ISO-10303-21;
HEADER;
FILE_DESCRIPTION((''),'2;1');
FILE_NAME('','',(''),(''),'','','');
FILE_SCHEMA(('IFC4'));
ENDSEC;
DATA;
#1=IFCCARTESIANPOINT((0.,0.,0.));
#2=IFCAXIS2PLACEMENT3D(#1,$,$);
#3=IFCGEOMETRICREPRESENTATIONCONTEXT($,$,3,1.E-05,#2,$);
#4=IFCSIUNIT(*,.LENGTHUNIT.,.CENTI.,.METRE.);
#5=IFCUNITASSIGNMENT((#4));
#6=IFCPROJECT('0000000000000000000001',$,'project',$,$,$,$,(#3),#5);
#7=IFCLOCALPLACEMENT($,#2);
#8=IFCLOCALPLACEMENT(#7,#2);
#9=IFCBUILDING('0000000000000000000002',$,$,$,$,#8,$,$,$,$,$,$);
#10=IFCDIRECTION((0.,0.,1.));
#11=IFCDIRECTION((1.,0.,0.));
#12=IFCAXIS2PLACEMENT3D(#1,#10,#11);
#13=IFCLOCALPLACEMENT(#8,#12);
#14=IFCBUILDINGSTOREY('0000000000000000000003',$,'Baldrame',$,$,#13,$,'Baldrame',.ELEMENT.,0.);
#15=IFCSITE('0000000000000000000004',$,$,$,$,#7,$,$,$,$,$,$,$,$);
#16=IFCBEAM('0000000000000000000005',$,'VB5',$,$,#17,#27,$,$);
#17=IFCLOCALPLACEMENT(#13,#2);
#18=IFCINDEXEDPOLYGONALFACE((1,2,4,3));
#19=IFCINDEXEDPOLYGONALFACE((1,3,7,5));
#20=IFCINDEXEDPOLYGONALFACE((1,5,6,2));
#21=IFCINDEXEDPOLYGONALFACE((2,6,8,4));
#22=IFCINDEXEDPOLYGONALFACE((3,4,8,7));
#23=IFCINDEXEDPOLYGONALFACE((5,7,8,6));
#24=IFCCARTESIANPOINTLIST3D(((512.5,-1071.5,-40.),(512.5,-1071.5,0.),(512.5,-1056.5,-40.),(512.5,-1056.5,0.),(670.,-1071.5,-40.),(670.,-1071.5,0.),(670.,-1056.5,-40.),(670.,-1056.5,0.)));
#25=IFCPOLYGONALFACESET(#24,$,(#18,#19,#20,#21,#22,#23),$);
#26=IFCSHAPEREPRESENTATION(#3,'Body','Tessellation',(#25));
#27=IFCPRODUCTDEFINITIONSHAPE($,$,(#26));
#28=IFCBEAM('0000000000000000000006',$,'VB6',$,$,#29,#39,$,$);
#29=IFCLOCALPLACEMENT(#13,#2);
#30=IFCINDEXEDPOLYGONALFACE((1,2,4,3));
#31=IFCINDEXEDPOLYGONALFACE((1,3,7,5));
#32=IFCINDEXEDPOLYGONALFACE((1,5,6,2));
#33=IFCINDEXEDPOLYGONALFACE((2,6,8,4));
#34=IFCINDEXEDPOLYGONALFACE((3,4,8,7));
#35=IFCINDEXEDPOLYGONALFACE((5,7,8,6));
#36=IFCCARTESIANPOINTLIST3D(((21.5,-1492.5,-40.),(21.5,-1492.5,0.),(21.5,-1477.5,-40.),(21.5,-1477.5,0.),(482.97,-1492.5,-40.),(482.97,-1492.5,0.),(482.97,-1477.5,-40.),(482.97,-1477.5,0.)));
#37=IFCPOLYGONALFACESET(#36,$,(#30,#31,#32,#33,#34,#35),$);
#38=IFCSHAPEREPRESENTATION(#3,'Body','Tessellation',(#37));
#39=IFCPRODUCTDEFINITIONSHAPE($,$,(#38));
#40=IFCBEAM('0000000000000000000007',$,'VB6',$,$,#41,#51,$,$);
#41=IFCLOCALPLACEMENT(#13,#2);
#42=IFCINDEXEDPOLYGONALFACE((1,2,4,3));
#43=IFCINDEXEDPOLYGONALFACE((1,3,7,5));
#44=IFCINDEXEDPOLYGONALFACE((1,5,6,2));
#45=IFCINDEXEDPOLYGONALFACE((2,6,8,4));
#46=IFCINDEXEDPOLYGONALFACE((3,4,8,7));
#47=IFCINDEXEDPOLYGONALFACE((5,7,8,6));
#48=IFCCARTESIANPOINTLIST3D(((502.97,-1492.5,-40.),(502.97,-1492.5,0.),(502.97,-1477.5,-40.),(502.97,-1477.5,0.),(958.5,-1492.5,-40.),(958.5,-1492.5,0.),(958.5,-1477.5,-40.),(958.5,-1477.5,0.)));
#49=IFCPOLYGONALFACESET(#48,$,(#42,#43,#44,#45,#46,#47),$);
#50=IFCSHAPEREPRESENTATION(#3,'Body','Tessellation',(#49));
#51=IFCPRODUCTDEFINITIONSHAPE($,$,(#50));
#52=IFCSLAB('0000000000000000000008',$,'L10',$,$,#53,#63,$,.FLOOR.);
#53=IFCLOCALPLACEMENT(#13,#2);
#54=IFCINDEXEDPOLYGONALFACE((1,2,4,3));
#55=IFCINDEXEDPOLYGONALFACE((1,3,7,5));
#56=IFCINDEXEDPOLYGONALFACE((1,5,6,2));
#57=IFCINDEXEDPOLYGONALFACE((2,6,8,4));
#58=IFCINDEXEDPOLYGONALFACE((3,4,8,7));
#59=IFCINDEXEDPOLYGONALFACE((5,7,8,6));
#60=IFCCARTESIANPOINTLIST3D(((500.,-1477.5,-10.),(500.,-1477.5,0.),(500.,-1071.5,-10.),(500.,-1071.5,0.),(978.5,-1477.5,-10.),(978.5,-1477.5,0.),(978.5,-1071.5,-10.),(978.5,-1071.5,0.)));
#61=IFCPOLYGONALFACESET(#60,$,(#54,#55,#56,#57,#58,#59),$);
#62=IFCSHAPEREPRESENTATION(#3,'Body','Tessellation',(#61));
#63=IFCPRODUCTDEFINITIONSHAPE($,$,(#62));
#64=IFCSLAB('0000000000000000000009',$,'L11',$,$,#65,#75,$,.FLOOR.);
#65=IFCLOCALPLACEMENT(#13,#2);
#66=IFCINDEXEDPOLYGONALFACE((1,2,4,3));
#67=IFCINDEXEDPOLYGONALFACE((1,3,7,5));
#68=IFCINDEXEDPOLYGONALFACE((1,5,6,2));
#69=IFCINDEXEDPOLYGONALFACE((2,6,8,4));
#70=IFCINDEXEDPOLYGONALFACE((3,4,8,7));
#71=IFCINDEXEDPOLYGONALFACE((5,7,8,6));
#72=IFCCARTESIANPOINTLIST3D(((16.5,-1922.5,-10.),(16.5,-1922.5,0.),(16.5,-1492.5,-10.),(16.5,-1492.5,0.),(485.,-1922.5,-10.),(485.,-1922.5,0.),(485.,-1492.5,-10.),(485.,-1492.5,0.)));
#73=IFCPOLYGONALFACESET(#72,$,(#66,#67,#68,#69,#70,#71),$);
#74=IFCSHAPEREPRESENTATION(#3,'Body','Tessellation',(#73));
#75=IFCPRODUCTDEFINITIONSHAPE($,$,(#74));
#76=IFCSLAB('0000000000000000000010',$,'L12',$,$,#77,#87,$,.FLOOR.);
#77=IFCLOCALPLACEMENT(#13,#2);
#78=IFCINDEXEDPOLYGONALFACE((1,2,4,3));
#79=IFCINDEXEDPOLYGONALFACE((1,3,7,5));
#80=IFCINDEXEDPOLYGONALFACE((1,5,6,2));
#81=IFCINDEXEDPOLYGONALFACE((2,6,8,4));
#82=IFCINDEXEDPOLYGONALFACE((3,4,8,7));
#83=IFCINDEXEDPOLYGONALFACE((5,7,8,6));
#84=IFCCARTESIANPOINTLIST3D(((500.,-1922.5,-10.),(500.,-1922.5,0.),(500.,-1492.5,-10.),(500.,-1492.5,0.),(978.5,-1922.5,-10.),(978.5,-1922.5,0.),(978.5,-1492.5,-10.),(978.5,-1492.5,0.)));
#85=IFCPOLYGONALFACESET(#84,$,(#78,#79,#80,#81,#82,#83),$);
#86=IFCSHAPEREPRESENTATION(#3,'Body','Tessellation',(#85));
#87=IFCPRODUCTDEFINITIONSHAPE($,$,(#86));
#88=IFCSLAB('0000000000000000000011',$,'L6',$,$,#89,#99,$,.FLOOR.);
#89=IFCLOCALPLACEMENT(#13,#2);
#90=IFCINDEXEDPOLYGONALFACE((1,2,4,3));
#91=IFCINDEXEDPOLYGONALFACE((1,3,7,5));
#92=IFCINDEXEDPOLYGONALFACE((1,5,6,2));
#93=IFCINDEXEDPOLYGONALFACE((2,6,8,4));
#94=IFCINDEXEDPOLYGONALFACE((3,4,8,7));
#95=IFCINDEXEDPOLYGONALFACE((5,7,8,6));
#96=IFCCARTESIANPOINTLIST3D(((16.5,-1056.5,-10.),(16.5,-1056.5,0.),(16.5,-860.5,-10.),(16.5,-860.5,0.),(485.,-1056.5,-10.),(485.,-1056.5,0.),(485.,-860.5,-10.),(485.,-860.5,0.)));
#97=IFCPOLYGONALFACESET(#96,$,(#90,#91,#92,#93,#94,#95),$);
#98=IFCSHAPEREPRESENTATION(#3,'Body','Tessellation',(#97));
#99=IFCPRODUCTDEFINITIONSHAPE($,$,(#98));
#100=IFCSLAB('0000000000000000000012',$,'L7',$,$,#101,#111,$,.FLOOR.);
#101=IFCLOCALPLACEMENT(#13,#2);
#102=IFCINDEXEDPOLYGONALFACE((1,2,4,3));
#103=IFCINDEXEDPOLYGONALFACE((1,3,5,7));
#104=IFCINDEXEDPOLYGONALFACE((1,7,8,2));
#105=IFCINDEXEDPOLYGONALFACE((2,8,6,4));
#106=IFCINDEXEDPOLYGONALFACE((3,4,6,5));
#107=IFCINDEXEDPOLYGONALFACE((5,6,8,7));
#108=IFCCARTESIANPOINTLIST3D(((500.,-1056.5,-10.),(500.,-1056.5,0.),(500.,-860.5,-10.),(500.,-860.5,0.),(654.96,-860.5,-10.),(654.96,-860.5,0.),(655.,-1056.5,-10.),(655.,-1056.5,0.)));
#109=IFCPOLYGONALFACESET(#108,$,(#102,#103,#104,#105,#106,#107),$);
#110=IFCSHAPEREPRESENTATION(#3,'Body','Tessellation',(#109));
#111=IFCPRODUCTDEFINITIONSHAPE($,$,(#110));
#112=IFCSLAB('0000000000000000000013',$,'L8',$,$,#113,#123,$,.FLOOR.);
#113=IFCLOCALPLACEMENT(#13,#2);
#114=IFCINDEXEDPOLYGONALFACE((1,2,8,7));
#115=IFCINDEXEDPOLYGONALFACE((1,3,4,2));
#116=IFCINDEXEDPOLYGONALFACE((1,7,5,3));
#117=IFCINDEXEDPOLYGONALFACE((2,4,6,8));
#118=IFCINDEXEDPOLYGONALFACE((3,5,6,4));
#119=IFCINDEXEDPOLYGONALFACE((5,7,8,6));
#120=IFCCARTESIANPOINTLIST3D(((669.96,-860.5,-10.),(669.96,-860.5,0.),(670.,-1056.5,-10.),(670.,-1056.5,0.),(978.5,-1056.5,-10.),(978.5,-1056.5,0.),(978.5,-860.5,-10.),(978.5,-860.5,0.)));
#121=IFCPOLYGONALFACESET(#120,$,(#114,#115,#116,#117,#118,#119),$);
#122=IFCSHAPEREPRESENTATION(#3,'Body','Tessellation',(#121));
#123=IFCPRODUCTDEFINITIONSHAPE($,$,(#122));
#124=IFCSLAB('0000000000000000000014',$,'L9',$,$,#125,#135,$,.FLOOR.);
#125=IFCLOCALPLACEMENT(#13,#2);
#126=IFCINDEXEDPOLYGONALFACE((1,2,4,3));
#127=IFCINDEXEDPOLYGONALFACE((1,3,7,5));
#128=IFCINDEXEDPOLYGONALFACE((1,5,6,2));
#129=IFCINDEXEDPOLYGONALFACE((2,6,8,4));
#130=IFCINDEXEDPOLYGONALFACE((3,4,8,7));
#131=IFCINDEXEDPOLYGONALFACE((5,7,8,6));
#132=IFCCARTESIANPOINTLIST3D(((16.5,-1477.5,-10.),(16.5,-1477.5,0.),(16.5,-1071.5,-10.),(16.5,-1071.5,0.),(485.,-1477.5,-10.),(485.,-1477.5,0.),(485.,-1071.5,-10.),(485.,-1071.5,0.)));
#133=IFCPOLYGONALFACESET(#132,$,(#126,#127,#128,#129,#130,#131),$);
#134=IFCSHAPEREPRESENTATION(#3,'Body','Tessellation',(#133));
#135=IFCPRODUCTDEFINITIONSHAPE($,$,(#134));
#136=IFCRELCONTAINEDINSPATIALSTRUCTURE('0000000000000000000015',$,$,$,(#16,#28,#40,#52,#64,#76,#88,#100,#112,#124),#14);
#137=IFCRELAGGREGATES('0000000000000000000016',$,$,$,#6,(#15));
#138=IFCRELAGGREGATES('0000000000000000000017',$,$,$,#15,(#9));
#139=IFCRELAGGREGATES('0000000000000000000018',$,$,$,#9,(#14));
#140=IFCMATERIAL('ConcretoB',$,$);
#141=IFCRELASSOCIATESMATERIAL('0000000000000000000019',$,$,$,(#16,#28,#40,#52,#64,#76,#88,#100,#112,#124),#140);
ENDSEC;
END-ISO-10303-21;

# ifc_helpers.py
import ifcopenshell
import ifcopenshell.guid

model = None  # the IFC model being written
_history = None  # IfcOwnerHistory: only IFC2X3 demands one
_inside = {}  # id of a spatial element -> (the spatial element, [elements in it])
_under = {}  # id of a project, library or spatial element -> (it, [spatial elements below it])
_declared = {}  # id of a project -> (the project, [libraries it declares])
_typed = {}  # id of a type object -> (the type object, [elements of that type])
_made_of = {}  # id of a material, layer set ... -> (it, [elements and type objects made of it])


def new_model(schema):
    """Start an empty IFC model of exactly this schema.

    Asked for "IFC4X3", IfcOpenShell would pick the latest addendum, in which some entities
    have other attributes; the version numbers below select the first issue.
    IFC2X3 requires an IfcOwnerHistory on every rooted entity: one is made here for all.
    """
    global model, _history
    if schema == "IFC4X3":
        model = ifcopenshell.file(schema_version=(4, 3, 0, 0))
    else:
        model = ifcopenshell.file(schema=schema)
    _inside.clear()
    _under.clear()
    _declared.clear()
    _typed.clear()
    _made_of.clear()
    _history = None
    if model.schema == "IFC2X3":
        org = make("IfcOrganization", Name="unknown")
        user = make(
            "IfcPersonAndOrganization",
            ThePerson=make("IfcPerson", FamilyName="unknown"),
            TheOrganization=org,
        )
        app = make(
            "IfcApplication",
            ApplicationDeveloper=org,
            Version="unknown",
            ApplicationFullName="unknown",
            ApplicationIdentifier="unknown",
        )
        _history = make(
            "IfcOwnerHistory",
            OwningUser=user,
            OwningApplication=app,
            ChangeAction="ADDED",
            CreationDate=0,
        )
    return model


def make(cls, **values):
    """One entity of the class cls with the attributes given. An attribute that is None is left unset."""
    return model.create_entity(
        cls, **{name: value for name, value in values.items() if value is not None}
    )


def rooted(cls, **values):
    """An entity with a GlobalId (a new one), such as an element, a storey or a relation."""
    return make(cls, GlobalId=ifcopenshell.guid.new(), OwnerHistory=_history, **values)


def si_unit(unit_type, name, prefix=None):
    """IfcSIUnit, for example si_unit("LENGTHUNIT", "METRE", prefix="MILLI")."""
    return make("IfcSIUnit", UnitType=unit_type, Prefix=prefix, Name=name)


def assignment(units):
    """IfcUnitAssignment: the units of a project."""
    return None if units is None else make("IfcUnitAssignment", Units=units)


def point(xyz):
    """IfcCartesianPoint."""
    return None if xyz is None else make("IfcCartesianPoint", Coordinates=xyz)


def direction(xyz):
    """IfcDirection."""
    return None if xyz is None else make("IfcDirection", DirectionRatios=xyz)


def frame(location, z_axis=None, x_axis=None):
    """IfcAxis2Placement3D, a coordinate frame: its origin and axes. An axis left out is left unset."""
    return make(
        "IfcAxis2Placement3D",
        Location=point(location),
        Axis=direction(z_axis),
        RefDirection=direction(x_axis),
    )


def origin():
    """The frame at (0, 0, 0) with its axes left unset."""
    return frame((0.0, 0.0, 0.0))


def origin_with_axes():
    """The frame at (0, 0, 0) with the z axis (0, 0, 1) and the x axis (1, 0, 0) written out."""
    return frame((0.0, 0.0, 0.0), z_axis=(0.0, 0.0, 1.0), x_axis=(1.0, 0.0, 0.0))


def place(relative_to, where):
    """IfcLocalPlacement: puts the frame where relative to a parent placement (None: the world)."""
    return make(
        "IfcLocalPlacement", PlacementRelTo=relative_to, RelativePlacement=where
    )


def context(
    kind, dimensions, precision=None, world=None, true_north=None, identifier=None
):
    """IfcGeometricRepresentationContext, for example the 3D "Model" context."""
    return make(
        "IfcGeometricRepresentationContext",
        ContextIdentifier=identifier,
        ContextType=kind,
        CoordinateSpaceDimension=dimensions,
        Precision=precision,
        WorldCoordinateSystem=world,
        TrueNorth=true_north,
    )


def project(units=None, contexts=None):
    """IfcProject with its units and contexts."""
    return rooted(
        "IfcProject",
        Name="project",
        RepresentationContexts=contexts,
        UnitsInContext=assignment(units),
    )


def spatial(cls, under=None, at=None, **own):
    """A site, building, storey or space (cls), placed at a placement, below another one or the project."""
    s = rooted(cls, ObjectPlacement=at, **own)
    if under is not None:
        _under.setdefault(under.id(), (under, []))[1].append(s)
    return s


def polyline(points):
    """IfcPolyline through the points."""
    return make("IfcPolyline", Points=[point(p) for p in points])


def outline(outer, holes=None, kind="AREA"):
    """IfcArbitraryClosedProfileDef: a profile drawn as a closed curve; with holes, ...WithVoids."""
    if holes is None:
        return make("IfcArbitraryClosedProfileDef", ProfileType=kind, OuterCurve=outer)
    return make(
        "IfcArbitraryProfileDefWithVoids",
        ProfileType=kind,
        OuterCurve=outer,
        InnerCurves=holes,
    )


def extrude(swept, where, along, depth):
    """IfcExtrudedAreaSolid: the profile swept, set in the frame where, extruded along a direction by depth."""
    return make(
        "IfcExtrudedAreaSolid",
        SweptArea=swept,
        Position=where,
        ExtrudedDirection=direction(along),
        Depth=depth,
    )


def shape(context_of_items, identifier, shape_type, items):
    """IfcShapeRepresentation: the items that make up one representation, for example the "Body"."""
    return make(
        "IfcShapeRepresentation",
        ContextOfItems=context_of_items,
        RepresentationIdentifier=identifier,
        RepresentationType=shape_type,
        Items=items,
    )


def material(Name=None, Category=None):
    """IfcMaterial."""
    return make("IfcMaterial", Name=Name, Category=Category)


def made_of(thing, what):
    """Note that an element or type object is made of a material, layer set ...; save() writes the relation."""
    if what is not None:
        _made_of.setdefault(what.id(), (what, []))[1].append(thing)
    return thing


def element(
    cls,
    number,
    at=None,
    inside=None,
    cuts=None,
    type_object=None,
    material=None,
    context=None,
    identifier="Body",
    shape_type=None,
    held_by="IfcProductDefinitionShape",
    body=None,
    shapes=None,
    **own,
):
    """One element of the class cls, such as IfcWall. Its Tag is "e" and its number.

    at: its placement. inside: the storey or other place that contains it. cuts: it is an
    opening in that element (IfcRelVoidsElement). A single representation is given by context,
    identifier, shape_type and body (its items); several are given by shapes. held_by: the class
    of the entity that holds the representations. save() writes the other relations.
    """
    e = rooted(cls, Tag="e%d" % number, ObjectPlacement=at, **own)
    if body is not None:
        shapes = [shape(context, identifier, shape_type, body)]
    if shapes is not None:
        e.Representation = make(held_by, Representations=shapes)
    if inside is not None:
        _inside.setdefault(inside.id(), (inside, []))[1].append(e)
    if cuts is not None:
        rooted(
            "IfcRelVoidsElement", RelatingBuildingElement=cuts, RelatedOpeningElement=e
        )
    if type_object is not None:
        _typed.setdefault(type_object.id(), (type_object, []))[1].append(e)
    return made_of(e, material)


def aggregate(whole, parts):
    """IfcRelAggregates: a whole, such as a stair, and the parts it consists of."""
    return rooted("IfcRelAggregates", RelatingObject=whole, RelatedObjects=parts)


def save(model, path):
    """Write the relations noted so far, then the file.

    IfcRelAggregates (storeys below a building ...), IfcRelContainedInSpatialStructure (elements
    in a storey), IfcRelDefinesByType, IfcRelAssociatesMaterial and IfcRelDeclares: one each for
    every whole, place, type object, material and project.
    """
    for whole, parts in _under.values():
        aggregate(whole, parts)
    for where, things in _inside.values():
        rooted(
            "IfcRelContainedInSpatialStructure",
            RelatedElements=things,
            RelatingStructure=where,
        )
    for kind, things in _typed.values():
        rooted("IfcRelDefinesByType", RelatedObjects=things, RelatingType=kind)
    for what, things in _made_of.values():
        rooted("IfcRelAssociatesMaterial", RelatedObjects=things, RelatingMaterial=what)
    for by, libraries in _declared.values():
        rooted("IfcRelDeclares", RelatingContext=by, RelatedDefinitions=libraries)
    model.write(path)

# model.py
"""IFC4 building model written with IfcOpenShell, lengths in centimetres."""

from ifc_helpers import new_model, si_unit, frame, origin, origin_with_axes, place, context, project, spatial, polyline, outline, extrude, material, element, save


model = new_model("IFC4")

# Units and contexts
context_of_model = context(None, 3, precision=1e-05, world=origin())
ifc_project = project(units=[si_unit("LENGTHUNIT", "METRE", prefix="CENTI")], contexts=[context_of_model])

# Site, building, storey
site_placement = place(None, origin())
site = spatial("IfcSite", under=ifc_project, at=site_placement)
building_placement = place(site_placement, origin())
building = spatial("IfcBuilding", under=site, at=building_placement)
storey_placement = place(building_placement, origin_with_axes())
storey = spatial("IfcBuildingStorey", under=building, at=storey_placement, Name="Baldrame", LongName="Baldrame", CompositionType="ELEMENT", Elevation=0.0)

# Shared definitions
ifc_material = material(Name="ConcretoB")

# Beams
beam_1_placement = place(storey_placement, frame((591.25, -1064.0, 0.0), z_axis=(0.0, 0.0, 1.0), x_axis=(1.0, 0.0, 0.0)))
element("IfcBeam", 1, at=beam_1_placement, inside=storey, material=ifc_material, Name="VB5", context=context_of_model, shape_type="SolidModel", body=[
    extrude(outline(polyline([(-7.5, -20.0), (7.5, -20.0), (7.5, 20.0), (-7.5, 20.0), (-7.5, -20.0)])), frame((-78.75, 0.0, -20.0), z_axis=(1.0, 0.0, 0.0), x_axis=(0.0, -1.0, 0.0)), (0.0, 0.0, 1.0), 157.5),
])
beam_2_placement = place(storey_placement, frame((252.24, -1485.0, 0.0), z_axis=(0.0, 0.0, 1.0), x_axis=(1.0, 0.0, 0.0)))
element("IfcBeam", 2, at=beam_2_placement, inside=storey, material=ifc_material, Name="VB6", context=context_of_model, shape_type="SolidModel", body=[
    extrude(outline(polyline([(-7.5, -20.0), (7.5, -20.0), (7.5, 20.0), (-7.5, 20.0), (-7.5, -20.0)])), frame((-230.74, 0.0, -20.0), z_axis=(1.0, 0.0, 0.0), x_axis=(0.0, -1.0, 0.0)), (0.0, 0.0, 1.0), 461.47),
])
beam_3_placement = place(storey_placement, frame((730.74, -1485.0, 0.0), z_axis=(0.0, 0.0, 1.0), x_axis=(1.0, 0.0, 0.0)))
element("IfcBeam", 3, at=beam_3_placement, inside=storey, material=ifc_material, Name="VB6", context=context_of_model, shape_type="SolidModel", body=[
    extrude(outline(polyline([(-7.5, -20.0), (7.5, -20.0), (7.5, 20.0), (-7.5, 20.0), (-7.5, -20.0)])), frame((-227.76, 0.0, -20.0), z_axis=(1.0, 0.0, 0.0), x_axis=(0.0, -1.0, 0.0)), (0.0, 0.0, 1.0), 455.53),
])

# Slabs
slab_1_placement = place(storey_placement, frame((739.25, -1274.5, 0.0), z_axis=(0.0, 0.0, 1.0), x_axis=(1.0, 0.0, 0.0)))
element("IfcSlab", 4, at=slab_1_placement, inside=storey, material=ifc_material, Name="L10", PredefinedType="FLOOR", context=context_of_model, shape_type="SolidModel", body=[
    extrude(outline(polyline([(239.25, 203.0), (-239.25, 203.0), (-239.25, -203.0), (239.25, -203.0), (239.25, 203.0), (239.25, 203.0)])), frame((0.0, 0.0, -10.0), z_axis=(0.0, 0.0, 1.0), x_axis=(1.0, 0.0, 0.0)), (0.0, 0.0, 1.0), 10.0),
])
slab_2_placement = place(storey_placement, frame((250.75, -1707.5, 0.0), z_axis=(0.0, 0.0, 1.0), x_axis=(1.0, 0.0, 0.0)))
element("IfcSlab", 5, at=slab_2_placement, inside=storey, material=ifc_material, Name="L11", PredefinedType="FLOOR", context=context_of_model, shape_type="SolidModel", body=[
    extrude(outline(polyline([(234.25, 215.0), (-234.25, 215.0), (-234.25, -215.0), (234.25, -215.0), (234.25, 215.0), (234.25, 215.0)])), frame((0.0, 0.0, -10.0), z_axis=(0.0, 0.0, 1.0), x_axis=(1.0, 0.0, 0.0)), (0.0, 0.0, 1.0), 10.0),
])
slab_3_placement = place(storey_placement, frame((739.25, -1707.5, 0.0), z_axis=(0.0, 0.0, 1.0), x_axis=(1.0, 0.0, 0.0)))
element("IfcSlab", 6, at=slab_3_placement, inside=storey, material=ifc_material, Name="L12", PredefinedType="FLOOR", context=context_of_model, shape_type="SolidModel", body=[
    extrude(outline(polyline([(239.25, 215.0), (-239.25, 215.0), (-239.25, -215.0), (239.25, -215.0), (239.25, 215.0), (239.25, 215.0)])), frame((0.0, 0.0, -10.0), z_axis=(0.0, 0.0, 1.0), x_axis=(1.0, 0.0, 0.0)), (0.0, 0.0, 1.0), 10.0),
])
slab_4_placement = place(storey_placement, frame((250.75, -958.5, 0.0), z_axis=(0.0, 0.0, 1.0), x_axis=(1.0, 0.0, 0.0)))
element("IfcSlab", 7, at=slab_4_placement, inside=storey, material=ifc_material, Name="L6", PredefinedType="FLOOR", context=context_of_model, shape_type="SolidModel", body=[
    extrude(outline(polyline([(234.25, 98.0), (-234.25, 98.0), (-234.25, -98.0), (234.25, -98.0), (234.25, 98.0), (234.25, 98.0)])), frame((0.0, 0.0, -10.0), z_axis=(0.0, 0.0, 1.0), x_axis=(1.0, 0.0, 0.0)), (0.0, 0.0, 1.0), 10.0),
])
slab_5_placement = place(storey_placement, frame((577.5, -958.5, 0.0), z_axis=(0.0, 0.0, 1.0), x_axis=(1.0, 0.0, 0.0)))
element("IfcSlab", 8, at=slab_5_placement, inside=storey, material=ifc_material, Name="L7", PredefinedType="FLOOR", context=context_of_model, shape_type="SolidModel", body=[
    extrude(outline(polyline([(77.5, -98.0), (77.46, 98.0), (-77.5, 98.0), (-77.5, -98.0), (77.5, -98.0), (77.5, -98.0)])), frame((0.0, 0.0, -10.0), z_axis=(0.0, 0.0, 1.0), x_axis=(1.0, 0.0, 0.0)), (0.0, 0.0, 1.0), 10.0),
])
slab_6_placement = place(storey_placement, frame((824.23, -958.5, 0.0), z_axis=(0.0, 0.0, 1.0), x_axis=(1.0, 0.0, 0.0)))
element("IfcSlab", 9, at=slab_6_placement, inside=storey, material=ifc_material, Name="L8", PredefinedType="FLOOR", context=context_of_model, shape_type="SolidModel", body=[
    extrude(outline(polyline([(154.27, 98.0), (-154.27, 98.0), (-154.23, -98.0), (154.27, -98.0), (154.27, 98.0), (154.27, 98.0)])), frame((0.0, 0.0, -10.0), z_axis=(0.0, 0.0, 1.0), x_axis=(1.0, 0.0, 0.0)), (0.0, 0.0, 1.0), 10.0),
])
slab_7_placement = place(storey_placement, frame((250.75, -1274.5, 0.0), z_axis=(0.0, 0.0, 1.0), x_axis=(1.0, 0.0, 0.0)))
element("IfcSlab", 10, at=slab_7_placement, inside=storey, material=ifc_material, Name="L9", PredefinedType="FLOOR", context=context_of_model, shape_type="SolidModel", body=[
    extrude(outline(polyline([(234.25, 203.0), (-234.25, 203.0), (-234.25, -203.0), (234.25, -203.0), (234.25, 203.0), (234.25, 203.0)])), frame((0.0, 0.0, -10.0), z_axis=(0.0, 0.0, 1.0), x_axis=(1.0, 0.0, 0.0)), (0.0, 0.0, 1.0), 10.0),
])

save(model, "model.ifc")
